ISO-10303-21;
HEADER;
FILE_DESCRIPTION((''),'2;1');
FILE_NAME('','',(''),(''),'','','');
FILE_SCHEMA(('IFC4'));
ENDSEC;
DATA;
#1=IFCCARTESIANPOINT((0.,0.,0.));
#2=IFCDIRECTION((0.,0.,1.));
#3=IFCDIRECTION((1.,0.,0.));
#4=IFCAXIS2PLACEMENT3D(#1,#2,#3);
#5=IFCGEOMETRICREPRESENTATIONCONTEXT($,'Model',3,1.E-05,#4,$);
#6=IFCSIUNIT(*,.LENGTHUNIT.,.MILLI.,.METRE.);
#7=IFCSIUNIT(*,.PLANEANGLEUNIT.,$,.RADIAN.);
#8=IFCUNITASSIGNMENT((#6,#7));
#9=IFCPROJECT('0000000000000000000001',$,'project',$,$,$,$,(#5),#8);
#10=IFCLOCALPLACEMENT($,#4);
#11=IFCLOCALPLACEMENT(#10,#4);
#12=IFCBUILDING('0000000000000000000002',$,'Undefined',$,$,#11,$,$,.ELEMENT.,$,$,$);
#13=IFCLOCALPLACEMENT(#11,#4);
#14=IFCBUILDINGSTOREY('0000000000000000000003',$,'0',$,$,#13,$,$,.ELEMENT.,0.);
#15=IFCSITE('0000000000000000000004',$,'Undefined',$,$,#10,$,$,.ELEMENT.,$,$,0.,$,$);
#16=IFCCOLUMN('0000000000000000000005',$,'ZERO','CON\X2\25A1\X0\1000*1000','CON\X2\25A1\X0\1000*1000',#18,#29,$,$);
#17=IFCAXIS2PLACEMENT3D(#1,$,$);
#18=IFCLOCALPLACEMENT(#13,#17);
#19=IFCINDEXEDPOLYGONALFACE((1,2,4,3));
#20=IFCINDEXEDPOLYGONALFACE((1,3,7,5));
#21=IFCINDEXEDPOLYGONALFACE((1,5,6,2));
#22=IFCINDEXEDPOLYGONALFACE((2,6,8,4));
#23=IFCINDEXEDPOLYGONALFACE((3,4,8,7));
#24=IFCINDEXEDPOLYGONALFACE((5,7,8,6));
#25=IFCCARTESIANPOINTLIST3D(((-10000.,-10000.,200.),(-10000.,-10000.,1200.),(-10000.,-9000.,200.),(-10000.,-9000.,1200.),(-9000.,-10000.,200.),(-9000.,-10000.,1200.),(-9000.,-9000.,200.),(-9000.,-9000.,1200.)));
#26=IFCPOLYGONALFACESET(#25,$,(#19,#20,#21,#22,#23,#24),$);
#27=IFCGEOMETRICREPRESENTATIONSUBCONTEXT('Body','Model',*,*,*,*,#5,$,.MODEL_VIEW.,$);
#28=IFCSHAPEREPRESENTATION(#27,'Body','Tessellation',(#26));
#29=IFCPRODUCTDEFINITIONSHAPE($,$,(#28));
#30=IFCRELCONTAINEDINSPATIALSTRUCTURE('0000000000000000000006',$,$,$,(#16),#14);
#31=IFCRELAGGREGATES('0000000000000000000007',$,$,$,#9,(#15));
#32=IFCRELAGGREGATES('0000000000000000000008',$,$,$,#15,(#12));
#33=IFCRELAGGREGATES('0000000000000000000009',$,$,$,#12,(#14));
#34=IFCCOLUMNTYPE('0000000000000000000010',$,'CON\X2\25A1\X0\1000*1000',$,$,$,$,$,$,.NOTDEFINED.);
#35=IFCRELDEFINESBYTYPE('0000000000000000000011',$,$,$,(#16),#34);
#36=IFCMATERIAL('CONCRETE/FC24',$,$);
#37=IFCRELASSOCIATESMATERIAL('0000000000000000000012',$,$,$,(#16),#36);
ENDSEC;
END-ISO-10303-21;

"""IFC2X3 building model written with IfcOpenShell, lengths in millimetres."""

from ifc_helpers import new_model, si_unit, frame, origin_with_axes, origin_2d_with_axis, place, context, subcontext, project, spatial, rectangle, extrude, material, type_object, element, save


model = new_model("IFC2X3")

# Units and contexts
model_context = context("Model", 3, precision=1e-05, world=origin_with_axes())
body_context = subcontext(model_context, "Body", "Model", "MODEL_VIEW")
ifc_project = project(units=[si_unit("LENGTHUNIT", "METRE", prefix="MILLI"), si_unit("PLANEANGLEUNIT", "RADIAN")], contexts=[model_context])

# Site, building, storey
site_placement = place(None, origin_with_axes())
site = spatial("IfcSite", under=ifc_project, at=site_placement, Name="Undefined", CompositionType="ELEMENT", RefElevation=0.0)
building_placement = place(site_placement, origin_with_axes())
building = spatial("IfcBuilding", under=site, at=building_placement, Name="Undefined", CompositionType="ELEMENT")
storey_placement = place(building_placement, origin_with_axes())
storey = spatial("IfcBuildingStorey", under=building, at=storey_placement, Name="0", CompositionType="ELEMENT", Elevation=0.0)

# Column
ifc_material = material(Name="CONCRETE/FC24")
column_type = type_object("IfcColumnType", Name="CON□1000*1000", PredefinedType="NOTDEFINED")
column_placement = place(storey_placement, frame((-9500.0, -9500.0, 200.0), z_axis=(0.0, 0.0, 1.0), x_axis=(0.0, 1.0, 0.0)))
element("IfcColumn", 1, at=column_placement, inside=storey, type_object=column_type, material=ifc_material, Name="ZERO", Description="CON□1000*1000", ObjectType="CON□1000*1000", context=body_context, shape_type="SweptSolid", body=[
    extrude(rectangle(XDim=1000.0, YDim=1000.0, at=origin_2d_with_axis()), frame((0.0, 0.0, 1000.0), z_axis=(0.0, 0.0, -1.0), x_axis=(0.0, 1.0, 0.0)), (0.0, 0.0, 1.0), 1000.0),
])

save(model, "model.ifc")
